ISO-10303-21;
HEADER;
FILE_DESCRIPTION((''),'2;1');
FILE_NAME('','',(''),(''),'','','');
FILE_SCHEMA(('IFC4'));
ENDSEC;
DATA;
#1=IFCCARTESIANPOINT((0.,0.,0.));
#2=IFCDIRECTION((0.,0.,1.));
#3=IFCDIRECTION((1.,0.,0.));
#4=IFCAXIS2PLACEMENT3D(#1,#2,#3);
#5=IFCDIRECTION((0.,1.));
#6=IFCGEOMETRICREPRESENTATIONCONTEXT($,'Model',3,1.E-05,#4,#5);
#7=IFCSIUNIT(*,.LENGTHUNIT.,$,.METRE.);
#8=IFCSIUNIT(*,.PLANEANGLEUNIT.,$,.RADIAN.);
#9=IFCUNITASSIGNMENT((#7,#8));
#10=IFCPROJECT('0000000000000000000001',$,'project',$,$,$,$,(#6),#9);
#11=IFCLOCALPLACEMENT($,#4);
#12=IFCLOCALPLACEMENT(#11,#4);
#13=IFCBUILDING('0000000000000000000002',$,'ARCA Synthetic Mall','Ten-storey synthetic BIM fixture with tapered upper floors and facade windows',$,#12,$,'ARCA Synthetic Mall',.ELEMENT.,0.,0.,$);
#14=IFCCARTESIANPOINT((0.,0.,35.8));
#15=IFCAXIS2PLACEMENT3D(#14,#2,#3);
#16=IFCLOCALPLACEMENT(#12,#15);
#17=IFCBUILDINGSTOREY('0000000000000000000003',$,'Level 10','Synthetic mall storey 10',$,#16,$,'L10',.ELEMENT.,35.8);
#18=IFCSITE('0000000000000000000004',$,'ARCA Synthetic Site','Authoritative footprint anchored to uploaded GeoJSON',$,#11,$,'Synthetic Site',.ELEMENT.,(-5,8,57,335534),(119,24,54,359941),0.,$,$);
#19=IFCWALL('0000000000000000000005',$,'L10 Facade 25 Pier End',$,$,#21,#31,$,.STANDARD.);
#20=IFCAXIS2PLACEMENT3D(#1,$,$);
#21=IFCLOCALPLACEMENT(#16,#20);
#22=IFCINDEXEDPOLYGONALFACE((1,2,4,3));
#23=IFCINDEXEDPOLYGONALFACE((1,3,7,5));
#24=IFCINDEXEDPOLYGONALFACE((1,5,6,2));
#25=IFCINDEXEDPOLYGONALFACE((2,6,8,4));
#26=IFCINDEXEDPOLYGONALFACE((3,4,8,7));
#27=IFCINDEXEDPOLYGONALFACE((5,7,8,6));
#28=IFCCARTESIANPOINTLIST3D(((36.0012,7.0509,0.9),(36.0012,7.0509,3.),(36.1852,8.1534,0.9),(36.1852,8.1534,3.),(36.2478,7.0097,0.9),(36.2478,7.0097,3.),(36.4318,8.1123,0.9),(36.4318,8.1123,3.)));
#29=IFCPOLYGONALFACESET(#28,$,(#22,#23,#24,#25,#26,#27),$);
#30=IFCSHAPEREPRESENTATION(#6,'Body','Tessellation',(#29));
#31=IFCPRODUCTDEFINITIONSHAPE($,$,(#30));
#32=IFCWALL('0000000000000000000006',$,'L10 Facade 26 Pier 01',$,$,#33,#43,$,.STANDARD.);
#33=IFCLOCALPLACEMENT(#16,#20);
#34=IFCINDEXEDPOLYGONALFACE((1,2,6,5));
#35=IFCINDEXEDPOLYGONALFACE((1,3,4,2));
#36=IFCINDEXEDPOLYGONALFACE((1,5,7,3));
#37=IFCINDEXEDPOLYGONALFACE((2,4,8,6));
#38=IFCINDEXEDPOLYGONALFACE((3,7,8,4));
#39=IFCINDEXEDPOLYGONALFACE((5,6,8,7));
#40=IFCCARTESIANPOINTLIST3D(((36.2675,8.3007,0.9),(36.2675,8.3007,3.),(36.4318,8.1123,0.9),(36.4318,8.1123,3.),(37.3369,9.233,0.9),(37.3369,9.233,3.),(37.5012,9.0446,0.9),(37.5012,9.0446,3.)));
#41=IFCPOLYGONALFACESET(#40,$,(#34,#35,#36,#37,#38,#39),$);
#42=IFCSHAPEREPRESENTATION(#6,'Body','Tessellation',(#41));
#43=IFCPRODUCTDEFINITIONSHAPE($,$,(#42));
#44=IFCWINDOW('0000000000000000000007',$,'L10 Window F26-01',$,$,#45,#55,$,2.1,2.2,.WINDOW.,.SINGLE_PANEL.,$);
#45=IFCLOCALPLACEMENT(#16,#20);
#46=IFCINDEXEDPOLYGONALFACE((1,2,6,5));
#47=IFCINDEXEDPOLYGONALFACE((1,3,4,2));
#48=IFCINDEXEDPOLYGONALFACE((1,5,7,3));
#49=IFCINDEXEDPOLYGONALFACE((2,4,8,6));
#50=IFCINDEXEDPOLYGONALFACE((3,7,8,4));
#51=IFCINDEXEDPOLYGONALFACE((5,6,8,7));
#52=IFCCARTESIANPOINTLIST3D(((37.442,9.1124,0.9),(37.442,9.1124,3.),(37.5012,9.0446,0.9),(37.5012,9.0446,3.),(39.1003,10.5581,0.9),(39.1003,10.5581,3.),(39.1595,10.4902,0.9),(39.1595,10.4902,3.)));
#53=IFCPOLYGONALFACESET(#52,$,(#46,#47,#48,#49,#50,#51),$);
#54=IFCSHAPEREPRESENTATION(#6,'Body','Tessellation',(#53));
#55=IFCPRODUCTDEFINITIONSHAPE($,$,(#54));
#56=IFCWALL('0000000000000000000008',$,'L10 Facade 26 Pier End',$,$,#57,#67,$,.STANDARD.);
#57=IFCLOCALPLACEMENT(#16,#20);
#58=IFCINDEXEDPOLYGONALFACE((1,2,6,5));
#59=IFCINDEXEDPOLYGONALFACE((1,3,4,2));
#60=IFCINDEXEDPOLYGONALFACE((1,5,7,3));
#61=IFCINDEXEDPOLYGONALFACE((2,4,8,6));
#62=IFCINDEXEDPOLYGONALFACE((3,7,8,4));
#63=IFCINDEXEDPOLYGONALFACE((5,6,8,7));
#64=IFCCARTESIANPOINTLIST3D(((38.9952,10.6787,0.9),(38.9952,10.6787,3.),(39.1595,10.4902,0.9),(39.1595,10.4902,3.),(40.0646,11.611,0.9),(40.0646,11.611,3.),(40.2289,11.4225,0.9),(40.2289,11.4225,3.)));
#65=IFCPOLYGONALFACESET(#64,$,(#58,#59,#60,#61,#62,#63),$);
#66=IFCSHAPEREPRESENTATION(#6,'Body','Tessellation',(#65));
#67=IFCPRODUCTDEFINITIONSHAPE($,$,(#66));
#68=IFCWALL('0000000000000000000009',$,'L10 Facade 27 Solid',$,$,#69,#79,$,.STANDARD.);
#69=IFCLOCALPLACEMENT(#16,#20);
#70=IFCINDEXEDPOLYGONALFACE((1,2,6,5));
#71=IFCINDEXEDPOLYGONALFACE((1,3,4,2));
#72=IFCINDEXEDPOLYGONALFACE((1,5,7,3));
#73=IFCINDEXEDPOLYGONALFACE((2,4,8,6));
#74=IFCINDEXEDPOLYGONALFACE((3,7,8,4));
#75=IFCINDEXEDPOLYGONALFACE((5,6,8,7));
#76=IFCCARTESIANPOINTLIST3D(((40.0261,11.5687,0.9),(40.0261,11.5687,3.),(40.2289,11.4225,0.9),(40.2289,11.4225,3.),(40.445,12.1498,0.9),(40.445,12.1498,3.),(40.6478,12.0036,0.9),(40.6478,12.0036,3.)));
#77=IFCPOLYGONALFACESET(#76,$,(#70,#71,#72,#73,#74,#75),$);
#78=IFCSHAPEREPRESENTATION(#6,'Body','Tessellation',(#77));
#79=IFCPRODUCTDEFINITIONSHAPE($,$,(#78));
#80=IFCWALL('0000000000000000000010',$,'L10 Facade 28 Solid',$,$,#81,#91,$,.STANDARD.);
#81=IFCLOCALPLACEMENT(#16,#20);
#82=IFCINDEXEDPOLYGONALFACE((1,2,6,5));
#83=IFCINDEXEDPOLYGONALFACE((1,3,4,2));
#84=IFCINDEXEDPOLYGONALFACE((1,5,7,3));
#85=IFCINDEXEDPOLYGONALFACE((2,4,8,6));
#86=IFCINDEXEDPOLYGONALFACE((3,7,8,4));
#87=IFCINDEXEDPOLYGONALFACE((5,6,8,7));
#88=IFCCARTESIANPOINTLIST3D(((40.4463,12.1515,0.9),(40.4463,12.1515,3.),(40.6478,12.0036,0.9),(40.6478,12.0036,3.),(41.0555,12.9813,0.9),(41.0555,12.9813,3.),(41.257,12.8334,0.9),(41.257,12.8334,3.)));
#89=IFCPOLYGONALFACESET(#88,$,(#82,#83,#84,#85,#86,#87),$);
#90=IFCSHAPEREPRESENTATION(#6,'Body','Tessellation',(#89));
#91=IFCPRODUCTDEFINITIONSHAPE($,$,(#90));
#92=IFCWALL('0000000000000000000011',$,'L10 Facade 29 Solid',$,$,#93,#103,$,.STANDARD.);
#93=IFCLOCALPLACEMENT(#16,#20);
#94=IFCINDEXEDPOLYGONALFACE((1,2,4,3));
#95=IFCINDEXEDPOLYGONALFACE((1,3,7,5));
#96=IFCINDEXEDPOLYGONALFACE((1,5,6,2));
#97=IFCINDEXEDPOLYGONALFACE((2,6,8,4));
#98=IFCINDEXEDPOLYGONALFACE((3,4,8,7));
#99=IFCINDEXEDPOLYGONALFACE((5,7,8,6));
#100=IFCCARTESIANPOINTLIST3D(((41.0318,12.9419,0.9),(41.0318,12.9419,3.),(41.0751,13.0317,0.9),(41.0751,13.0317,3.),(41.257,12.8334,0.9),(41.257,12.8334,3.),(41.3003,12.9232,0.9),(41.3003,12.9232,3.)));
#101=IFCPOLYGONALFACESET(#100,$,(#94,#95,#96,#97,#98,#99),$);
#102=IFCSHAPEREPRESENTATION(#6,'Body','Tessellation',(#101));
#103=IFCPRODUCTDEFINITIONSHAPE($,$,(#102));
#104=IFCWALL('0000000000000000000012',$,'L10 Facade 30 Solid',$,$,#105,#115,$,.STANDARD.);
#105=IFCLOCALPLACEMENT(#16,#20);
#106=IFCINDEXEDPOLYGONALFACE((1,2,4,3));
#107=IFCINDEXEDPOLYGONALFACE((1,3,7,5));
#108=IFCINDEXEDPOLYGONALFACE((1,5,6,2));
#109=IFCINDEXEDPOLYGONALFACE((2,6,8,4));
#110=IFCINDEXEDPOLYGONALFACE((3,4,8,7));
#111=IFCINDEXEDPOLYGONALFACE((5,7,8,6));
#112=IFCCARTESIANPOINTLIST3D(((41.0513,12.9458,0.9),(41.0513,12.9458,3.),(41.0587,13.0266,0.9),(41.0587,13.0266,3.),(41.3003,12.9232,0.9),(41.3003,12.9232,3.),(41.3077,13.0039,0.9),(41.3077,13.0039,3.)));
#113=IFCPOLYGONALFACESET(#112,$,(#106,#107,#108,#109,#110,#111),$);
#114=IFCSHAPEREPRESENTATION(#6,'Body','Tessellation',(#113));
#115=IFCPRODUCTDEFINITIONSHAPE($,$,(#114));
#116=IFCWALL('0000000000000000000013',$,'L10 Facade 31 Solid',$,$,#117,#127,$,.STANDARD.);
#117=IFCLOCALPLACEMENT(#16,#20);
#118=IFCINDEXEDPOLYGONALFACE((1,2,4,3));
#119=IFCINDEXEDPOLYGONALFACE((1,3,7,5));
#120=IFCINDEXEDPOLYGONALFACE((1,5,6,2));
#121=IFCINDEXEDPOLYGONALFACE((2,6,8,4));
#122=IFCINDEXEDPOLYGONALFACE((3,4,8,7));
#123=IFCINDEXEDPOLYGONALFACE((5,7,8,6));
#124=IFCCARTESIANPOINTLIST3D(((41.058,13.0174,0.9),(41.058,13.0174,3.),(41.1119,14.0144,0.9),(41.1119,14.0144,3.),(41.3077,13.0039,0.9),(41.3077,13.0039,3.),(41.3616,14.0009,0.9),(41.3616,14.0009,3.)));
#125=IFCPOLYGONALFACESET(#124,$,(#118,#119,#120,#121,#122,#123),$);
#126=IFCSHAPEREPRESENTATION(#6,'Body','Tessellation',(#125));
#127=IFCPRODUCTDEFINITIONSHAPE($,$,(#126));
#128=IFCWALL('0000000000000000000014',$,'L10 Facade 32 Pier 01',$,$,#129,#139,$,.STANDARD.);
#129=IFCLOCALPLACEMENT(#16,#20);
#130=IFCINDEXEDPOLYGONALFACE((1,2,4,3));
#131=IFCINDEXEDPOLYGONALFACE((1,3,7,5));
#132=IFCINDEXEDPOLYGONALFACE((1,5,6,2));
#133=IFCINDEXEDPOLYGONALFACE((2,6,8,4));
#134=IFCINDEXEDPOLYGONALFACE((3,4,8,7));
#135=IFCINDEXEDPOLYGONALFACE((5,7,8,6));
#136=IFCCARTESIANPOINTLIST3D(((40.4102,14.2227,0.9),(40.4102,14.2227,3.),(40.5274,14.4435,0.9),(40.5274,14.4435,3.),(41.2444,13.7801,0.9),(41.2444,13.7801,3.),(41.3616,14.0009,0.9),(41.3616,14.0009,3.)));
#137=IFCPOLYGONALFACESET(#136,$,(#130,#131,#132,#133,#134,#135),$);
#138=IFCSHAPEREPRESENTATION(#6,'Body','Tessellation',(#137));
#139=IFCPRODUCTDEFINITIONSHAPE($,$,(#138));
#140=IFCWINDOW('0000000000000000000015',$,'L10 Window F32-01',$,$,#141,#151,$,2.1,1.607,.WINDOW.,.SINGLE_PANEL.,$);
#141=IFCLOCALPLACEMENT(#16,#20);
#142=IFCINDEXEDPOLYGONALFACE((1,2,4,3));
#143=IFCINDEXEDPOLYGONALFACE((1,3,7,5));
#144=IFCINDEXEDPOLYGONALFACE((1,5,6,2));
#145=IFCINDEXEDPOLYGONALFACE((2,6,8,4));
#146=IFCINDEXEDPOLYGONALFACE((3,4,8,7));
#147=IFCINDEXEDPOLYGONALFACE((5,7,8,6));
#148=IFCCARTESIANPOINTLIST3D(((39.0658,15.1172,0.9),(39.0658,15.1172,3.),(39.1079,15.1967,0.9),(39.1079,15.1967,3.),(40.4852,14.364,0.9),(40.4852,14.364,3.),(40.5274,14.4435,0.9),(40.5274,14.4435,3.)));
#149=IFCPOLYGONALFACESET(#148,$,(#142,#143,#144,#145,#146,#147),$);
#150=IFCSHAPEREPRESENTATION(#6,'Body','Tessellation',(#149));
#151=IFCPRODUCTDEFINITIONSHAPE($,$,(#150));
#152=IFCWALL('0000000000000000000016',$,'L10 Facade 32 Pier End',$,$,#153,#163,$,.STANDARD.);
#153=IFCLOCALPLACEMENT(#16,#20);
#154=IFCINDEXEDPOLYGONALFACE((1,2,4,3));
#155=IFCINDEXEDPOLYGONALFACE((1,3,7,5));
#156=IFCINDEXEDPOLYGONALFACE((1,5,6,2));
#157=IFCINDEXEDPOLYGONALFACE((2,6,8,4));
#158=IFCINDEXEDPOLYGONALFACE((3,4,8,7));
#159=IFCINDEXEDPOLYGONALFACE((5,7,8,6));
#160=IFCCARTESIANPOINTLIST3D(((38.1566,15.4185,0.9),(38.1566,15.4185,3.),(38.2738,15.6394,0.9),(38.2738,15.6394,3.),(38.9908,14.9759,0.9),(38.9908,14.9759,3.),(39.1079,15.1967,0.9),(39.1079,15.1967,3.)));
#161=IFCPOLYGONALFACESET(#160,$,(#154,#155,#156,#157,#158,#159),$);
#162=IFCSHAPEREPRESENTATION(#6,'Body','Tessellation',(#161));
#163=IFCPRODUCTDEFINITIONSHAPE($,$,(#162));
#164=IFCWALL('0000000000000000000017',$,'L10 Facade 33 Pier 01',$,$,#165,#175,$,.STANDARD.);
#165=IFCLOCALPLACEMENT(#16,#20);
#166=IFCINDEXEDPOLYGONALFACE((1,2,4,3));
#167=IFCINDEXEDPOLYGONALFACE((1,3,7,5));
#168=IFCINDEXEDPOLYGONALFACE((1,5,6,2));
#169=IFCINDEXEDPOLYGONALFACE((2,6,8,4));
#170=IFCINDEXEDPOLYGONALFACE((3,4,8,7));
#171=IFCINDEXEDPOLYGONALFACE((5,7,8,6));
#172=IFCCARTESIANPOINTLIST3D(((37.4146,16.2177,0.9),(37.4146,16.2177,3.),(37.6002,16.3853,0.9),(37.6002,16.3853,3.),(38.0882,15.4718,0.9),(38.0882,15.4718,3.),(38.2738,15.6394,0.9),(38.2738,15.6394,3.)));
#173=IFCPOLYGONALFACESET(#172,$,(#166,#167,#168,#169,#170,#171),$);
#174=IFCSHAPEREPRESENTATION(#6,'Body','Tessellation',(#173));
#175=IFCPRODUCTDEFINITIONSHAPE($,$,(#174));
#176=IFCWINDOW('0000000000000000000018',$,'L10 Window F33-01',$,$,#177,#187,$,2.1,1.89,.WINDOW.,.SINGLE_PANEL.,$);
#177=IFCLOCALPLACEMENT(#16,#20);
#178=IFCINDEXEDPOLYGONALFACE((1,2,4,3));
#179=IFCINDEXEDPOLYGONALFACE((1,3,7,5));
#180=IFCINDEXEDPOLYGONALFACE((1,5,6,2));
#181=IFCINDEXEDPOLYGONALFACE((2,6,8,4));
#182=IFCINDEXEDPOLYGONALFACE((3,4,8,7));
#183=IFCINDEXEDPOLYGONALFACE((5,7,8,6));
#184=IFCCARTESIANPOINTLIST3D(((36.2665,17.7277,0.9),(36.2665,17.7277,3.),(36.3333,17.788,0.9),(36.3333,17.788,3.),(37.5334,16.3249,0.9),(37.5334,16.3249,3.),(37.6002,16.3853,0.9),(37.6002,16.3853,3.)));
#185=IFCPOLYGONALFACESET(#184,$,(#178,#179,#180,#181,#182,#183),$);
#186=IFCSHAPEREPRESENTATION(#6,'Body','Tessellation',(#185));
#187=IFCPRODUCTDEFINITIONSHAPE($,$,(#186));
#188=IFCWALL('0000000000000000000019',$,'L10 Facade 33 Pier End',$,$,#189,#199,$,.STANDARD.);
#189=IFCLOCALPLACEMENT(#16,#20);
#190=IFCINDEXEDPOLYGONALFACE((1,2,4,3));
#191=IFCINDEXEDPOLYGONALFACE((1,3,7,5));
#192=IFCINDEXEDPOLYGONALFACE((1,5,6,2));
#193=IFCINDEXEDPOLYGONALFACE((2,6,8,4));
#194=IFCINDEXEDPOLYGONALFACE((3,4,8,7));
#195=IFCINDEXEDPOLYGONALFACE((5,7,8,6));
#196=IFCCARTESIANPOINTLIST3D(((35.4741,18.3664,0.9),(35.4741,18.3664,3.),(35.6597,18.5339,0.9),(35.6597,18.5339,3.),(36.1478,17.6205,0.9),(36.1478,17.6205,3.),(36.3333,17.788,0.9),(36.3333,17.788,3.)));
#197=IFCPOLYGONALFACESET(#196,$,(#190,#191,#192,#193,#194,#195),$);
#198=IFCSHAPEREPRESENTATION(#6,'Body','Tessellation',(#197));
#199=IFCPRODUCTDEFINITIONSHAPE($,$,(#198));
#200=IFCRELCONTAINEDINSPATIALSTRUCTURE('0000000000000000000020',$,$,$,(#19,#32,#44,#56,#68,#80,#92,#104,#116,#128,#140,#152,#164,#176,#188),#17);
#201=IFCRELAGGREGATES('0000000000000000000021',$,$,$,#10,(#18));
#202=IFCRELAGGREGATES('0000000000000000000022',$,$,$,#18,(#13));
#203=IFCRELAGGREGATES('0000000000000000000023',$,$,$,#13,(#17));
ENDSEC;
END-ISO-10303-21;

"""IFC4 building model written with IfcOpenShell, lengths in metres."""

from ifc_helpers import new_model, si_unit, direction, frame, origin_with_axes, place, context, project, spatial, polyline, outline, extrude, element, save


model = new_model("IFC4")

# Units and contexts
model_context = context("Model", 3, precision=1e-05, world=origin_with_axes(), true_north=direction((0.0, 1.0)))
ifc_project = project(units=[si_unit("LENGTHUNIT", "METRE"), si_unit("PLANEANGLEUNIT", "RADIAN")], contexts=[model_context])

# Site, building, storey
site_placement = place(None, origin_with_axes())
site = spatial("IfcSite", under=ifc_project, at=site_placement, Name="ARCA Synthetic Site", Description="Authoritative footprint anchored to uploaded GeoJSON", LongName="Synthetic Site", CompositionType="ELEMENT", RefLatitude=(-5, 8, 57, 335534), RefLongitude=(119, 24, 54, 359941), RefElevation=0.0)
building_placement = place(site_placement, origin_with_axes())
building = spatial("IfcBuilding", under=site, at=building_placement, Name="ARCA Synthetic Mall", Description="Ten-storey synthetic BIM fixture with tapered upper floors and facade windows", LongName="ARCA Synthetic Mall", CompositionType="ELEMENT", ElevationOfRefHeight=0.0, ElevationOfTerrain=0.0)
storey_placement = place(building_placement, frame((0.0, 0.0, 35.8), z_axis=(0.0, 0.0, 1.0), x_axis=(1.0, 0.0, 0.0)))
storey = spatial("IfcBuildingStorey", under=building, at=storey_placement, Name="Level 10", Description="Synthetic mall storey 10", LongName="L10", CompositionType="ELEMENT", Elevation=35.8)

# Walls
wall_1_placement = place(storey_placement, frame((0.0, 0.0, 0.9), z_axis=(0.0, 0.0, 1.0), x_axis=(1.0, 0.0, 0.0)))
element("IfcWall", 1, at=wall_1_placement, inside=storey, Name="L10 Facade 25 Pier End", PredefinedType="STANDARD", context=model_context, shape_type="SweptSolid", body=[
    extrude(outline(polyline([(36.2478, 7.0097), (36.4318, 8.1123), (36.1852, 8.1534), (36.0012, 7.0509), (36.2478, 7.0097)])), origin_with_axes(), (0.0, 0.0, 1.0), 2.1),
])
wall_2_placement = place(storey_placement, frame((0.0, 0.0, 0.9), z_axis=(0.0, 0.0, 1.0), x_axis=(1.0, 0.0, 0.0)))
element("IfcWall", 2, at=wall_2_placement, inside=storey, Name="L10 Facade 26 Pier 01", PredefinedType="STANDARD", context=model_context, shape_type="SweptSolid", body=[
    extrude(outline(polyline([(36.4318, 8.1123), (37.5012, 9.0446), (37.3369, 9.233), (36.2675, 8.3007), (36.4318, 8.1123)])), origin_with_axes(), (0.0, 0.0, 1.0), 2.1),
])

# Window
window_1_placement = place(storey_placement, frame((0.0, 0.0, 0.9), z_axis=(0.0, 0.0, 1.0), x_axis=(1.0, 0.0, 0.0)))
element("IfcWindow", 3, at=window_1_placement, inside=storey, Name="L10 Window F26-01", OverallHeight=2.1, OverallWidth=2.2, PartitioningType="SINGLE_PANEL", PredefinedType="WINDOW", context=model_context, shape_type="SweptSolid", body=[
    extrude(outline(polyline([(37.5012, 9.0446), (39.1595, 10.4902), (39.1003, 10.5581), (37.442, 9.1124), (37.5012, 9.0446)])), origin_with_axes(), (0.0, 0.0, 1.0), 2.1),
])

# Walls
wall_3_placement = place(storey_placement, frame((0.0, 0.0, 0.9), z_axis=(0.0, 0.0, 1.0), x_axis=(1.0, 0.0, 0.0)))
element("IfcWall", 4, at=wall_3_placement, inside=storey, Name="L10 Facade 26 Pier End", PredefinedType="STANDARD", context=model_context, shape_type="SweptSolid", body=[
    extrude(outline(polyline([(39.1595, 10.4902), (40.2289, 11.4225), (40.0646, 11.611), (38.9952, 10.6787), (39.1595, 10.4902)])), origin_with_axes(), (0.0, 0.0, 1.0), 2.1),
])
wall_4_placement = place(storey_placement, frame((0.0, 0.0, 0.9), z_axis=(0.0, 0.0, 1.0), x_axis=(1.0, 0.0, 0.0)))
element("IfcWall", 5, at=wall_4_placement, inside=storey, Name="L10 Facade 27 Solid", PredefinedType="STANDARD", context=model_context, shape_type="SweptSolid", body=[
    extrude(outline(polyline([(40.2289, 11.4225), (40.6478, 12.0036), (40.445, 12.1498), (40.0261, 11.5687), (40.2289, 11.4225)])), origin_with_axes(), (0.0, 0.0, 1.0), 2.1),
])
wall_5_placement = place(storey_placement, frame((0.0, 0.0, 0.9), z_axis=(0.0, 0.0, 1.0), x_axis=(1.0, 0.0, 0.0)))
element("IfcWall", 6, at=wall_5_placement, inside=storey, Name="L10 Facade 28 Solid", PredefinedType="STANDARD", context=model_context, shape_type="SweptSolid", body=[
    extrude(outline(polyline([(40.6478, 12.0036), (41.257, 12.8334), (41.0555, 12.9813), (40.4463, 12.1515), (40.6478, 12.0036)])), origin_with_axes(), (0.0, 0.0, 1.0), 2.1),
])
wall_6_placement = place(storey_placement, frame((0.0, 0.0, 0.9), z_axis=(0.0, 0.0, 1.0), x_axis=(1.0, 0.0, 0.0)))
element("IfcWall", 7, at=wall_6_placement, inside=storey, Name="L10 Facade 29 Solid", PredefinedType="STANDARD", context=model_context, shape_type="SweptSolid", body=[
    extrude(outline(polyline([(41.257, 12.8334), (41.3003, 12.9232), (41.0751, 13.0317), (41.0318, 12.9419), (41.257, 12.8334)])), origin_with_axes(), (0.0, 0.0, 1.0), 2.1),
])
wall_7_placement = place(storey_placement, frame((0.0, 0.0, 0.9), z_axis=(0.0, 0.0, 1.0), x_axis=(1.0, 0.0, 0.0)))
element("IfcWall", 8, at=wall_7_placement, inside=storey, Name="L10 Facade 30 Solid", PredefinedType="STANDARD", context=model_context, shape_type="SweptSolid", body=[
    extrude(outline(polyline([(41.3003, 12.9232), (41.3077, 13.0039), (41.0587, 13.0266), (41.0513, 12.9458), (41.3003, 12.9232)])), origin_with_axes(), (0.0, 0.0, 1.0), 2.1),
])
wall_8_placement = place(storey_placement, frame((0.0, 0.0, 0.9), z_axis=(0.0, 0.0, 1.0), x_axis=(1.0, 0.0, 0.0)))
element("IfcWall", 9, at=wall_8_placement, inside=storey, Name="L10 Facade 31 Solid", PredefinedType="STANDARD", context=model_context, shape_type="SweptSolid", body=[
    extrude(outline(polyline([(41.3077, 13.0039), (41.3616, 14.0009), (41.1119, 14.0144), (41.058, 13.0174), (41.3077, 13.0039)])), origin_with_axes(), (0.0, 0.0, 1.0), 2.1),
])
wall_9_placement = place(storey_placement, frame((0.0, 0.0, 0.9), z_axis=(0.0, 0.0, 1.0), x_axis=(1.0, 0.0, 0.0)))
element("IfcWall", 10, at=wall_9_placement, inside=storey, Name="L10 Facade 32 Pier 01", PredefinedType="STANDARD", context=model_context, shape_type="SweptSolid", body=[
    extrude(outline(polyline([(41.3616, 14.0009), (40.5274, 14.4435), (40.4102, 14.2227), (41.2444, 13.7801), (41.3616, 14.0009)])), origin_with_axes(), (0.0, 0.0, 1.0), 2.1),
])

# Window
window_2_placement = place(storey_placement, frame((0.0, 0.0, 0.9), z_axis=(0.0, 0.0, 1.0), x_axis=(1.0, 0.0, 0.0)))
element("IfcWindow", 11, at=window_2_placement, inside=storey, Name="L10 Window F32-01", OverallHeight=2.1, OverallWidth=1.607, PartitioningType="SINGLE_PANEL", PredefinedType="WINDOW", context=model_context, shape_type="SweptSolid", body=[
    extrude(outline(polyline([(40.5274, 14.4435), (39.1079, 15.1967), (39.0658, 15.1172), (40.4852, 14.364), (40.5274, 14.4435)])), origin_with_axes(), (0.0, 0.0, 1.0), 2.1),
])

# Walls
wall_10_placement = place(storey_placement, frame((0.0, 0.0, 0.9), z_axis=(0.0, 0.0, 1.0), x_axis=(1.0, 0.0, 0.0)))
element("IfcWall", 12, at=wall_10_placement, inside=storey, Name="L10 Facade 32 Pier End", PredefinedType="STANDARD", context=model_context, shape_type="SweptSolid", body=[
    extrude(outline(polyline([(39.1079, 15.1967), (38.2738, 15.6394), (38.1566, 15.4185), (38.9908, 14.9759), (39.1079, 15.1967)])), origin_with_axes(), (0.0, 0.0, 1.0), 2.1),
])
wall_11_placement = place(storey_placement, frame((0.0, 0.0, 0.9), z_axis=(0.0, 0.0, 1.0), x_axis=(1.0, 0.0, 0.0)))
element("IfcWall", 13, at=wall_11_placement, inside=storey, Name="L10 Facade 33 Pier 01", PredefinedType="STANDARD", context=model_context, shape_type="SweptSolid", body=[
    extrude(outline(polyline([(38.2738, 15.6394), (37.6002, 16.3853), (37.4146, 16.2177), (38.0882, 15.4718), (38.2738, 15.6394)])), origin_with_axes(), (0.0, 0.0, 1.0), 2.1),
])

# Window
window_3_placement = place(storey_placement, frame((0.0, 0.0, 0.9), z_axis=(0.0, 0.0, 1.0), x_axis=(1.0, 0.0, 0.0)))
element("IfcWindow", 14, at=window_3_placement, inside=storey, Name="L10 Window F33-01", OverallHeight=2.1, OverallWidth=1.89, PartitioningType="SINGLE_PANEL", PredefinedType="WINDOW", context=model_context, shape_type="SweptSolid", body=[
    extrude(outline(polyline([(37.6002, 16.3853), (36.3333, 17.788), (36.2665, 17.7277), (37.5334, 16.3249), (37.6002, 16.3853)])), origin_with_axes(), (0.0, 0.0, 1.0), 2.1),
])

# Wall
wall_12_placement = place(storey_placement, frame((0.0, 0.0, 0.9), z_axis=(0.0, 0.0, 1.0), x_axis=(1.0, 0.0, 0.0)))
element("IfcWall", 15, at=wall_12_placement, inside=storey, Name="L10 Facade 33 Pier End", PredefinedType="STANDARD", context=model_context, shape_type="SweptSolid", body=[
    extrude(outline(polyline([(36.3333, 17.788), (35.6597, 18.5339), (35.4741, 18.3664), (36.1478, 17.6205), (36.3333, 17.788)])), origin_with_axes(), (0.0, 0.0, 1.0), 2.1),
])

save(model, "model.ifc")
